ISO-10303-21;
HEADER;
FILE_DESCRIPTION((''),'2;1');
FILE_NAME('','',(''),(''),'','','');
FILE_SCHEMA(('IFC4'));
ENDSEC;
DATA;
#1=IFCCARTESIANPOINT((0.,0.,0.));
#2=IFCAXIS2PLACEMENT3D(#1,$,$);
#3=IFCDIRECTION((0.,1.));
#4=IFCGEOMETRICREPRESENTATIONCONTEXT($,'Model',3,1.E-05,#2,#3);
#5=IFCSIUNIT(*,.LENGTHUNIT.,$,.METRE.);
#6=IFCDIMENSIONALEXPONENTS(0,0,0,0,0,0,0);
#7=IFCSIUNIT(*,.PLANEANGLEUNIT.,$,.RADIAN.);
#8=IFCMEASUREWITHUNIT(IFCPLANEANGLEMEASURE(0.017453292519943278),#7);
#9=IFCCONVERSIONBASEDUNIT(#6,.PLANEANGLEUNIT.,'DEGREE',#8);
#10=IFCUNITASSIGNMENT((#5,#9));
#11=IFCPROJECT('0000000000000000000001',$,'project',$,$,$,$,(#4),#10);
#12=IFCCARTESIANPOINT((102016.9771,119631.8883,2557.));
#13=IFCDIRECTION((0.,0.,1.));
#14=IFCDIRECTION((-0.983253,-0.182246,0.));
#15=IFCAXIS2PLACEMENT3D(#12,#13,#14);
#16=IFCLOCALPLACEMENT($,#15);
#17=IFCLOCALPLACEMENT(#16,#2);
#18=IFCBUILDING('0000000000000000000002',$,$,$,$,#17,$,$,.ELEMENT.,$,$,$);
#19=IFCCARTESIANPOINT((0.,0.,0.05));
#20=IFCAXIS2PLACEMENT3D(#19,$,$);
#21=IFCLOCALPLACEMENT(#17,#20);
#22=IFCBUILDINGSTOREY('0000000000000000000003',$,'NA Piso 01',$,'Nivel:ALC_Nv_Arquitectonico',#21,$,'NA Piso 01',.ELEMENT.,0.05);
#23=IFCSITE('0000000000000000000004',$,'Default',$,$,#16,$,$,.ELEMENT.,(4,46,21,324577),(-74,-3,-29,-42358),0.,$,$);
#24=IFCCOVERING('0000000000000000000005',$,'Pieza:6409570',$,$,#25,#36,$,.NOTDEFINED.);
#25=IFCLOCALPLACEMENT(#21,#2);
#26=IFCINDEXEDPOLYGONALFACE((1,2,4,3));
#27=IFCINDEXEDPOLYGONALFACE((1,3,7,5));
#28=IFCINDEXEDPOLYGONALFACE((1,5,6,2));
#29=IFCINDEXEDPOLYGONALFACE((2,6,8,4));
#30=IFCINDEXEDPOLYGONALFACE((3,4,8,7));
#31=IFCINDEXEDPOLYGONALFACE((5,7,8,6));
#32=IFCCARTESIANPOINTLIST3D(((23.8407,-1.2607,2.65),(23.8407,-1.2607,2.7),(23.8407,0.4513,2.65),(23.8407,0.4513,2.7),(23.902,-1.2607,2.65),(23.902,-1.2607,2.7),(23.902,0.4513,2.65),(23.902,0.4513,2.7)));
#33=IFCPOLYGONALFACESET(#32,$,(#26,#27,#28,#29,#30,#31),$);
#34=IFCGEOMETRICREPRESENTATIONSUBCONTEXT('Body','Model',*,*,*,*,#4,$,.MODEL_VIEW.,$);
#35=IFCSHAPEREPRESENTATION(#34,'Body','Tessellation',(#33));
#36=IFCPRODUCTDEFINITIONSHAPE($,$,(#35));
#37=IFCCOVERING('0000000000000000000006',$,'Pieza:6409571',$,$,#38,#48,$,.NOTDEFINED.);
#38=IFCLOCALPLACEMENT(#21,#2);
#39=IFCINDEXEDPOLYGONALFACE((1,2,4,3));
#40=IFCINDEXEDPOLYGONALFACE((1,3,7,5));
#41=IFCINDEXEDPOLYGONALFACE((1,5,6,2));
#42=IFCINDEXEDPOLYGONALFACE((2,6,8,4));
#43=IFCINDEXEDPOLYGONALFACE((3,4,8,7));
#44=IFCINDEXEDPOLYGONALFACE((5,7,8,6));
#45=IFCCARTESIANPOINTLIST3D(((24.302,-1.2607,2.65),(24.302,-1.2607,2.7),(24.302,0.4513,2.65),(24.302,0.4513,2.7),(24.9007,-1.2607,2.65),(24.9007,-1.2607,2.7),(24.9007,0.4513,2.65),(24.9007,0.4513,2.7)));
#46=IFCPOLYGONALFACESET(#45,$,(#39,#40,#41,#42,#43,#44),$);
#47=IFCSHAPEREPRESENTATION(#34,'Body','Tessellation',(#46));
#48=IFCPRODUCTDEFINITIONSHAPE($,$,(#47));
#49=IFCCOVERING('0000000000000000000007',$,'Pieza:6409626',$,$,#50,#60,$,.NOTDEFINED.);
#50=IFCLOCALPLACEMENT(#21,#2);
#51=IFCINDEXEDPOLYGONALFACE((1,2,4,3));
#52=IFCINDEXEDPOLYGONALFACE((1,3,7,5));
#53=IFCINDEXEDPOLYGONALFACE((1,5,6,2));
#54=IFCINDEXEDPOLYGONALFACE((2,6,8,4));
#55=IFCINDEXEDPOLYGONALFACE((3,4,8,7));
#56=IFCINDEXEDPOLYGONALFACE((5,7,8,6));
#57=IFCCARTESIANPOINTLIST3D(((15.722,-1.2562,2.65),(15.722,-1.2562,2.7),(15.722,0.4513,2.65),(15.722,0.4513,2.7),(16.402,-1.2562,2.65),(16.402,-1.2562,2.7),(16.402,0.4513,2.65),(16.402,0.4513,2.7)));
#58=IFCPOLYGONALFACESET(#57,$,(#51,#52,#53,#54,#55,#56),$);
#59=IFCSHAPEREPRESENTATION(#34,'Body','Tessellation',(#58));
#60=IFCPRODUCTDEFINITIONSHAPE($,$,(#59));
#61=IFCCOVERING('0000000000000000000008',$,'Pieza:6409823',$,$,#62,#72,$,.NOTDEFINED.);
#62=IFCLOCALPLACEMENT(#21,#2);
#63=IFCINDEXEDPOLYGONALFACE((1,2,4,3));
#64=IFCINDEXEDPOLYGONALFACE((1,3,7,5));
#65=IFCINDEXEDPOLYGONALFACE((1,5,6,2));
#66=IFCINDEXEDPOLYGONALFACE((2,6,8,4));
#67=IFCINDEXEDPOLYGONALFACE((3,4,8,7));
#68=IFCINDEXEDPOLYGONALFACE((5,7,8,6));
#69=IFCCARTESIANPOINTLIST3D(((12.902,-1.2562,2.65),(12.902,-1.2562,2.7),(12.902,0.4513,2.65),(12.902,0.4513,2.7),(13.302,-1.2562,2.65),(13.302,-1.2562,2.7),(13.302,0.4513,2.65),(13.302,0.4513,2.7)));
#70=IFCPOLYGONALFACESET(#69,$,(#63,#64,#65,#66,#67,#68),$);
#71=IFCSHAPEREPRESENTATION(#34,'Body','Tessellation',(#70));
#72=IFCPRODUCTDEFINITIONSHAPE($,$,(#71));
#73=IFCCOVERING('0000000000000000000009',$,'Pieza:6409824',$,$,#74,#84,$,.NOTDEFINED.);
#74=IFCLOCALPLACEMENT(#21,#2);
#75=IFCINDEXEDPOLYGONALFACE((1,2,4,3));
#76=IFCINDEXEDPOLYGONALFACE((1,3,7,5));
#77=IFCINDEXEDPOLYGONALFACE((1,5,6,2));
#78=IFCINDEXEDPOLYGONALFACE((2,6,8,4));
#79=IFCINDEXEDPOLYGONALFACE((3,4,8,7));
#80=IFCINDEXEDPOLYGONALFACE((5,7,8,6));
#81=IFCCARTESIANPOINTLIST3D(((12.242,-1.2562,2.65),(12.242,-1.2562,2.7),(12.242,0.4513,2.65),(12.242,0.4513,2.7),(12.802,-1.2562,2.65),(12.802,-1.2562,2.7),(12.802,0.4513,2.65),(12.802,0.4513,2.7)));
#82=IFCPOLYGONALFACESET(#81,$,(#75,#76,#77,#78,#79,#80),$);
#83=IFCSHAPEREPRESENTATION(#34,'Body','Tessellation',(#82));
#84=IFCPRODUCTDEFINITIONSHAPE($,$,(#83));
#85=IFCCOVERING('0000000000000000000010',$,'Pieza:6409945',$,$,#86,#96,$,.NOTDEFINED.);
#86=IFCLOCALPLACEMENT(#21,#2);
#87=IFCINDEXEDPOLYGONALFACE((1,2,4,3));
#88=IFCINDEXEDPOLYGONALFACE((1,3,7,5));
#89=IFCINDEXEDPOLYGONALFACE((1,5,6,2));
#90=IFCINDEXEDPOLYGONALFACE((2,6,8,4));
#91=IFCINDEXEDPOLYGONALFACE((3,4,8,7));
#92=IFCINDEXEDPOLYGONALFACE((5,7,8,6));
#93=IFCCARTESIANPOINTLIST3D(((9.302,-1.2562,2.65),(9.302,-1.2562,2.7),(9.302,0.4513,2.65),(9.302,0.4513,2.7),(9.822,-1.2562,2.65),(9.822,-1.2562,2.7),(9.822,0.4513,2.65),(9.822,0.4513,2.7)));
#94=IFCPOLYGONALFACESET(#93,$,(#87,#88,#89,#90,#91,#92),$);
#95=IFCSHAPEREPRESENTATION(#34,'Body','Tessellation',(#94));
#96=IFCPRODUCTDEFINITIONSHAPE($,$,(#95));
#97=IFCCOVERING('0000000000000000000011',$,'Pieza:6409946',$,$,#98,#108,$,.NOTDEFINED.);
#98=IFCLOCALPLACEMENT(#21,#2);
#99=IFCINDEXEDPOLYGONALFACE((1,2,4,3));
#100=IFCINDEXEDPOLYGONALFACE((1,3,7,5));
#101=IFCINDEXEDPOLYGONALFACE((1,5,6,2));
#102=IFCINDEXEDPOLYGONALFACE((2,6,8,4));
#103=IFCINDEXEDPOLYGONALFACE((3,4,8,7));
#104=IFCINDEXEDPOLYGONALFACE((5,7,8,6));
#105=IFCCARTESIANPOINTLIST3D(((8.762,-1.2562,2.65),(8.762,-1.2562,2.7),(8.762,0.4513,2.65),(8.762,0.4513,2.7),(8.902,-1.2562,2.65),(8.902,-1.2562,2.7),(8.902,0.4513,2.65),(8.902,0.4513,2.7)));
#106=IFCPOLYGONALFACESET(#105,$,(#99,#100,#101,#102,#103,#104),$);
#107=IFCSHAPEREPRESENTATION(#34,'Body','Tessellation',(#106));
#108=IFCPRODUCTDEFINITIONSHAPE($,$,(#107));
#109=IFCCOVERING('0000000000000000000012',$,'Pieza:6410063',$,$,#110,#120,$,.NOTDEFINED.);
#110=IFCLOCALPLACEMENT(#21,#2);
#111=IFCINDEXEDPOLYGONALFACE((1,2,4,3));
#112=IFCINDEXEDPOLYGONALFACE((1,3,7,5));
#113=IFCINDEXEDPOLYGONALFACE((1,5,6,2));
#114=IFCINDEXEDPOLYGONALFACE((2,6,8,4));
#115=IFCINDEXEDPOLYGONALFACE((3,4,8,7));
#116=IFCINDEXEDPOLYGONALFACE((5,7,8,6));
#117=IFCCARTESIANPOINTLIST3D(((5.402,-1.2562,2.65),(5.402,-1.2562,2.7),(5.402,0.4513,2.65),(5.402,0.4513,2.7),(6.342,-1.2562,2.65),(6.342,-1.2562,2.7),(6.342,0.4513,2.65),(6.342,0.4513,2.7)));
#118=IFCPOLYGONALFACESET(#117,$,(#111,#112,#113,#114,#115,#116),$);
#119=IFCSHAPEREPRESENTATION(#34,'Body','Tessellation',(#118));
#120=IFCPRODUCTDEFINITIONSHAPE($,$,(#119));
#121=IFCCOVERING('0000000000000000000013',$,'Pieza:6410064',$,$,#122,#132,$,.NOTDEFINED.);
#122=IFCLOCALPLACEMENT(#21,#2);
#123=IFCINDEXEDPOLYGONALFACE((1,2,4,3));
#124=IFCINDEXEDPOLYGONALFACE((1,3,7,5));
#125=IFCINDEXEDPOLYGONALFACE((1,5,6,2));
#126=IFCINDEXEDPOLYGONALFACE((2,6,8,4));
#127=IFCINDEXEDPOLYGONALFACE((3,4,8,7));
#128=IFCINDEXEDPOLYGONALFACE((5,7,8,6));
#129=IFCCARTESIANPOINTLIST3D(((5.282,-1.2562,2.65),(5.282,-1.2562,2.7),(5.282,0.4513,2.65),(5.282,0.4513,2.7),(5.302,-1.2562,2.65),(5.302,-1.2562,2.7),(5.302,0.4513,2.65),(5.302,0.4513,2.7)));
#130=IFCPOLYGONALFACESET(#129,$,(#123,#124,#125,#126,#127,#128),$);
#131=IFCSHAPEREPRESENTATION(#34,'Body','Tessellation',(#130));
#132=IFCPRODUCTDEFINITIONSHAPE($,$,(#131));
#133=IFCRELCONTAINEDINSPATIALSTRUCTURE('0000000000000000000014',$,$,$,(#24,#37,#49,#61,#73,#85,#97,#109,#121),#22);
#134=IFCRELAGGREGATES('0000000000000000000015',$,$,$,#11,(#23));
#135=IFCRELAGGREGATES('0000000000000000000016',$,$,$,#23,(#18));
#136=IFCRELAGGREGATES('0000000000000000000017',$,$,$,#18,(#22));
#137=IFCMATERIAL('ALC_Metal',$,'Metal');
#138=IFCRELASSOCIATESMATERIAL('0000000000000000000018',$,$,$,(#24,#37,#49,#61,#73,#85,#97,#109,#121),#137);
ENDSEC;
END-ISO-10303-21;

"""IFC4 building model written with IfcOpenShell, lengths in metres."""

from ifc_helpers import new_model, entity, si_unit, converted_unit, direction, frame, frame_2d, origin, origin_2d_with_axis, place, context, subcontext, project, spatial, rectangle, extrude, material, element, save


model = new_model("IFC4")

# Units and contexts
model_context = context("Model", 3, precision=1e-05, world=origin(), true_north=direction((0.0, 1.0)))
body_context = subcontext(model_context, "Body", "Model", "MODEL_VIEW")
ifc_project = project(units=[si_unit("LENGTHUNIT", "METRE"), converted_unit("PLANEANGLEUNIT", "DEGREE", entity("IfcPlaneAngleMeasure", 0.017453292519943278), si_unit("PLANEANGLEUNIT", "RADIAN"), dimensions=[0, 0, 0, 0, 0, 0, 0])], contexts=[model_context])

# Site, building, storey
site_placement = place(None, frame((102016.9771, 119631.8883, 2557.0), z_axis=(0.0, 0.0, 1.0), x_axis=(-0.983253, -0.182246, 0.0)))
site = spatial("IfcSite", under=ifc_project, at=site_placement, Name="Default", CompositionType="ELEMENT", RefLatitude=(4, 46, 21, 324577), RefLongitude=(-74, -3, -29, -42358), RefElevation=0.0)
building_placement = place(site_placement, origin())
building = spatial("IfcBuilding", under=site, at=building_placement, CompositionType="ELEMENT")
storey_placement = place(building_placement, frame((0.0, 0.0, 0.05)))
storey = spatial("IfcBuildingStorey", under=building, at=storey_placement, Name="NA Piso 01", ObjectType="Nivel:ALC_Nv_Arquitectonico", LongName="NA Piso 01", CompositionType="ELEMENT", Elevation=0.05)

# Coverings
ifc_material_1 = material(Name="ALC_Metal", Category="Metal")
covering_1_placement = place(storey_placement, frame((0.0, 0.0, 2.65)))
element("IfcCovering", 1, at=covering_1_placement, inside=storey, material=ifc_material_1, Name="Pieza:6409570", PredefinedType="NOTDEFINED", context=body_context, shape_type="SweptSolid", body=[
    extrude(rectangle(XDim=1.712, YDim=0.0613, at=frame_2d((0.0, 0.0), x_axis=(1.0, 0.0))), frame((23.8714, -0.4047, 0.0), z_axis=(0.0, 0.0, 1.0), x_axis=(0.0, -1.0, 0.0)), (0.0, 0.0, 1.0), 0.05),
])
covering_2_placement = place(storey_placement, frame((0.0, 0.0, 2.65)))
element("IfcCovering", 2, at=covering_2_placement, inside=storey, material=ifc_material_1, Name="Pieza:6409571", PredefinedType="NOTDEFINED", context=body_context, shape_type="SweptSolid", body=[
    extrude(rectangle(XDim=1.712, YDim=0.5987, at=frame_2d((0.0, 0.0), x_axis=(1.0, 0.0))), frame((24.6014, -0.4047, 0.0), z_axis=(0.0, 0.0, 1.0), x_axis=(0.0, -1.0, 0.0)), (0.0, 0.0, 1.0), 0.05),
])
covering_3_placement = place(storey_placement, frame((0.0, 0.0, 2.65)))
element("IfcCovering", 3, at=covering_3_placement, inside=storey, material=ifc_material_1, Name="Pieza:6409626", PredefinedType="NOTDEFINED", context=body_context, shape_type="SweptSolid", body=[
    extrude(rectangle(XDim=1.7075, YDim=0.68, at=frame_2d((0.0, 0.0), x_axis=(1.0, 0.0))), frame((16.062, -0.4024, 0.0), z_axis=(0.0, 0.0, 1.0), x_axis=(0.0, -1.0, 0.0)), (0.0, 0.0, 1.0), 0.05),
])
covering_4_placement = place(storey_placement, frame((0.0, 0.0, 2.65)))
element("IfcCovering", 4, at=covering_4_placement, inside=storey, material=ifc_material_1, Name="Pieza:6409823", PredefinedType="NOTDEFINED", context=body_context, shape_type="SweptSolid", body=[
    extrude(rectangle(XDim=1.7075, YDim=0.4, at=frame_2d((0.0, 0.0), x_axis=(1.0, 0.0))), frame((13.102, -0.4024, 0.0), z_axis=(0.0, 0.0, 1.0), x_axis=(0.0, -1.0, 0.0)), (0.0, 0.0, 1.0), 0.05),
])
covering_5_placement = place(storey_placement, frame((0.0, 0.0, 2.65)))
element("IfcCovering", 5, at=covering_5_placement, inside=storey, material=ifc_material_1, Name="Pieza:6409824", PredefinedType="NOTDEFINED", context=body_context, shape_type="SweptSolid", body=[
    extrude(rectangle(XDim=1.7075, YDim=0.56, at=frame_2d((0.0, 0.0), x_axis=(1.0, 0.0))), frame((12.522, -0.4024, 0.0), z_axis=(0.0, 0.0, 1.0), x_axis=(0.0, -1.0, 0.0)), (0.0, 0.0, 1.0), 0.05),
])
covering_6_placement = place(storey_placement, frame((0.0, 0.0, 2.65)))
element("IfcCovering", 6, at=covering_6_placement, inside=storey, material=ifc_material_1, Name="Pieza:6409945", PredefinedType="NOTDEFINED", context=body_context, shape_type="SweptSolid", body=[
    extrude(rectangle(XDim=1.7075, YDim=0.52, at=frame_2d((0.0, 0.0), x_axis=(1.0, 0.0))), frame((9.562, -0.4024, 0.0), z_axis=(0.0, 0.0, 1.0), x_axis=(0.0, -1.0, 0.0)), (0.0, 0.0, 1.0), 0.05),
])
covering_7_placement = place(storey_placement, frame((0.0, 0.0, 2.65)))
element("IfcCovering", 7, at=covering_7_placement, inside=storey, material=ifc_material_1, Name="Pieza:6409946", PredefinedType="NOTDEFINED", context=body_context, shape_type="SweptSolid", body=[
    extrude(rectangle(XDim=1.7075, YDim=0.14, at=frame_2d((0.0, 0.0), x_axis=(1.0, 0.0))), frame((8.832, -0.4024, 0.0), z_axis=(0.0, 0.0, 1.0), x_axis=(0.0, -1.0, 0.0)), (0.0, 0.0, 1.0), 0.05),
])
covering_8_placement = place(storey_placement, frame((0.0, 0.0, 2.65)))
element("IfcCovering", 8, at=covering_8_placement, inside=storey, material=ifc_material_1, Name="Pieza:6410063", PredefinedType="NOTDEFINED", context=body_context, shape_type="SweptSolid", body=[
    extrude(rectangle(XDim=1.7075, YDim=0.94, at=frame_2d((0.0, 0.0), x_axis=(1.0, 0.0))), frame((5.872, -0.4024, 0.0), z_axis=(0.0, 0.0, 1.0), x_axis=(0.0, -1.0, 0.0)), (0.0, 0.0, 1.0), 0.05),
])
covering_9_placement = place(storey_placement, frame((0.0, 0.0, 2.65)))
element("IfcCovering", 9, at=covering_9_placement, inside=storey, material=ifc_material_1, Name="Pieza:6410064", PredefinedType="NOTDEFINED", context=body_context, shape_type="SweptSolid", body=[
    extrude(rectangle(XDim=1.7075, YDim=0.02, at=origin_2d_with_axis()), frame((5.292, -0.4024, 0.0), z_axis=(0.0, 0.0, 1.0), x_axis=(0.0, -1.0, 0.0)), (0.0, 0.0, 1.0), 0.05),
])

save(model, "model.ifc")
